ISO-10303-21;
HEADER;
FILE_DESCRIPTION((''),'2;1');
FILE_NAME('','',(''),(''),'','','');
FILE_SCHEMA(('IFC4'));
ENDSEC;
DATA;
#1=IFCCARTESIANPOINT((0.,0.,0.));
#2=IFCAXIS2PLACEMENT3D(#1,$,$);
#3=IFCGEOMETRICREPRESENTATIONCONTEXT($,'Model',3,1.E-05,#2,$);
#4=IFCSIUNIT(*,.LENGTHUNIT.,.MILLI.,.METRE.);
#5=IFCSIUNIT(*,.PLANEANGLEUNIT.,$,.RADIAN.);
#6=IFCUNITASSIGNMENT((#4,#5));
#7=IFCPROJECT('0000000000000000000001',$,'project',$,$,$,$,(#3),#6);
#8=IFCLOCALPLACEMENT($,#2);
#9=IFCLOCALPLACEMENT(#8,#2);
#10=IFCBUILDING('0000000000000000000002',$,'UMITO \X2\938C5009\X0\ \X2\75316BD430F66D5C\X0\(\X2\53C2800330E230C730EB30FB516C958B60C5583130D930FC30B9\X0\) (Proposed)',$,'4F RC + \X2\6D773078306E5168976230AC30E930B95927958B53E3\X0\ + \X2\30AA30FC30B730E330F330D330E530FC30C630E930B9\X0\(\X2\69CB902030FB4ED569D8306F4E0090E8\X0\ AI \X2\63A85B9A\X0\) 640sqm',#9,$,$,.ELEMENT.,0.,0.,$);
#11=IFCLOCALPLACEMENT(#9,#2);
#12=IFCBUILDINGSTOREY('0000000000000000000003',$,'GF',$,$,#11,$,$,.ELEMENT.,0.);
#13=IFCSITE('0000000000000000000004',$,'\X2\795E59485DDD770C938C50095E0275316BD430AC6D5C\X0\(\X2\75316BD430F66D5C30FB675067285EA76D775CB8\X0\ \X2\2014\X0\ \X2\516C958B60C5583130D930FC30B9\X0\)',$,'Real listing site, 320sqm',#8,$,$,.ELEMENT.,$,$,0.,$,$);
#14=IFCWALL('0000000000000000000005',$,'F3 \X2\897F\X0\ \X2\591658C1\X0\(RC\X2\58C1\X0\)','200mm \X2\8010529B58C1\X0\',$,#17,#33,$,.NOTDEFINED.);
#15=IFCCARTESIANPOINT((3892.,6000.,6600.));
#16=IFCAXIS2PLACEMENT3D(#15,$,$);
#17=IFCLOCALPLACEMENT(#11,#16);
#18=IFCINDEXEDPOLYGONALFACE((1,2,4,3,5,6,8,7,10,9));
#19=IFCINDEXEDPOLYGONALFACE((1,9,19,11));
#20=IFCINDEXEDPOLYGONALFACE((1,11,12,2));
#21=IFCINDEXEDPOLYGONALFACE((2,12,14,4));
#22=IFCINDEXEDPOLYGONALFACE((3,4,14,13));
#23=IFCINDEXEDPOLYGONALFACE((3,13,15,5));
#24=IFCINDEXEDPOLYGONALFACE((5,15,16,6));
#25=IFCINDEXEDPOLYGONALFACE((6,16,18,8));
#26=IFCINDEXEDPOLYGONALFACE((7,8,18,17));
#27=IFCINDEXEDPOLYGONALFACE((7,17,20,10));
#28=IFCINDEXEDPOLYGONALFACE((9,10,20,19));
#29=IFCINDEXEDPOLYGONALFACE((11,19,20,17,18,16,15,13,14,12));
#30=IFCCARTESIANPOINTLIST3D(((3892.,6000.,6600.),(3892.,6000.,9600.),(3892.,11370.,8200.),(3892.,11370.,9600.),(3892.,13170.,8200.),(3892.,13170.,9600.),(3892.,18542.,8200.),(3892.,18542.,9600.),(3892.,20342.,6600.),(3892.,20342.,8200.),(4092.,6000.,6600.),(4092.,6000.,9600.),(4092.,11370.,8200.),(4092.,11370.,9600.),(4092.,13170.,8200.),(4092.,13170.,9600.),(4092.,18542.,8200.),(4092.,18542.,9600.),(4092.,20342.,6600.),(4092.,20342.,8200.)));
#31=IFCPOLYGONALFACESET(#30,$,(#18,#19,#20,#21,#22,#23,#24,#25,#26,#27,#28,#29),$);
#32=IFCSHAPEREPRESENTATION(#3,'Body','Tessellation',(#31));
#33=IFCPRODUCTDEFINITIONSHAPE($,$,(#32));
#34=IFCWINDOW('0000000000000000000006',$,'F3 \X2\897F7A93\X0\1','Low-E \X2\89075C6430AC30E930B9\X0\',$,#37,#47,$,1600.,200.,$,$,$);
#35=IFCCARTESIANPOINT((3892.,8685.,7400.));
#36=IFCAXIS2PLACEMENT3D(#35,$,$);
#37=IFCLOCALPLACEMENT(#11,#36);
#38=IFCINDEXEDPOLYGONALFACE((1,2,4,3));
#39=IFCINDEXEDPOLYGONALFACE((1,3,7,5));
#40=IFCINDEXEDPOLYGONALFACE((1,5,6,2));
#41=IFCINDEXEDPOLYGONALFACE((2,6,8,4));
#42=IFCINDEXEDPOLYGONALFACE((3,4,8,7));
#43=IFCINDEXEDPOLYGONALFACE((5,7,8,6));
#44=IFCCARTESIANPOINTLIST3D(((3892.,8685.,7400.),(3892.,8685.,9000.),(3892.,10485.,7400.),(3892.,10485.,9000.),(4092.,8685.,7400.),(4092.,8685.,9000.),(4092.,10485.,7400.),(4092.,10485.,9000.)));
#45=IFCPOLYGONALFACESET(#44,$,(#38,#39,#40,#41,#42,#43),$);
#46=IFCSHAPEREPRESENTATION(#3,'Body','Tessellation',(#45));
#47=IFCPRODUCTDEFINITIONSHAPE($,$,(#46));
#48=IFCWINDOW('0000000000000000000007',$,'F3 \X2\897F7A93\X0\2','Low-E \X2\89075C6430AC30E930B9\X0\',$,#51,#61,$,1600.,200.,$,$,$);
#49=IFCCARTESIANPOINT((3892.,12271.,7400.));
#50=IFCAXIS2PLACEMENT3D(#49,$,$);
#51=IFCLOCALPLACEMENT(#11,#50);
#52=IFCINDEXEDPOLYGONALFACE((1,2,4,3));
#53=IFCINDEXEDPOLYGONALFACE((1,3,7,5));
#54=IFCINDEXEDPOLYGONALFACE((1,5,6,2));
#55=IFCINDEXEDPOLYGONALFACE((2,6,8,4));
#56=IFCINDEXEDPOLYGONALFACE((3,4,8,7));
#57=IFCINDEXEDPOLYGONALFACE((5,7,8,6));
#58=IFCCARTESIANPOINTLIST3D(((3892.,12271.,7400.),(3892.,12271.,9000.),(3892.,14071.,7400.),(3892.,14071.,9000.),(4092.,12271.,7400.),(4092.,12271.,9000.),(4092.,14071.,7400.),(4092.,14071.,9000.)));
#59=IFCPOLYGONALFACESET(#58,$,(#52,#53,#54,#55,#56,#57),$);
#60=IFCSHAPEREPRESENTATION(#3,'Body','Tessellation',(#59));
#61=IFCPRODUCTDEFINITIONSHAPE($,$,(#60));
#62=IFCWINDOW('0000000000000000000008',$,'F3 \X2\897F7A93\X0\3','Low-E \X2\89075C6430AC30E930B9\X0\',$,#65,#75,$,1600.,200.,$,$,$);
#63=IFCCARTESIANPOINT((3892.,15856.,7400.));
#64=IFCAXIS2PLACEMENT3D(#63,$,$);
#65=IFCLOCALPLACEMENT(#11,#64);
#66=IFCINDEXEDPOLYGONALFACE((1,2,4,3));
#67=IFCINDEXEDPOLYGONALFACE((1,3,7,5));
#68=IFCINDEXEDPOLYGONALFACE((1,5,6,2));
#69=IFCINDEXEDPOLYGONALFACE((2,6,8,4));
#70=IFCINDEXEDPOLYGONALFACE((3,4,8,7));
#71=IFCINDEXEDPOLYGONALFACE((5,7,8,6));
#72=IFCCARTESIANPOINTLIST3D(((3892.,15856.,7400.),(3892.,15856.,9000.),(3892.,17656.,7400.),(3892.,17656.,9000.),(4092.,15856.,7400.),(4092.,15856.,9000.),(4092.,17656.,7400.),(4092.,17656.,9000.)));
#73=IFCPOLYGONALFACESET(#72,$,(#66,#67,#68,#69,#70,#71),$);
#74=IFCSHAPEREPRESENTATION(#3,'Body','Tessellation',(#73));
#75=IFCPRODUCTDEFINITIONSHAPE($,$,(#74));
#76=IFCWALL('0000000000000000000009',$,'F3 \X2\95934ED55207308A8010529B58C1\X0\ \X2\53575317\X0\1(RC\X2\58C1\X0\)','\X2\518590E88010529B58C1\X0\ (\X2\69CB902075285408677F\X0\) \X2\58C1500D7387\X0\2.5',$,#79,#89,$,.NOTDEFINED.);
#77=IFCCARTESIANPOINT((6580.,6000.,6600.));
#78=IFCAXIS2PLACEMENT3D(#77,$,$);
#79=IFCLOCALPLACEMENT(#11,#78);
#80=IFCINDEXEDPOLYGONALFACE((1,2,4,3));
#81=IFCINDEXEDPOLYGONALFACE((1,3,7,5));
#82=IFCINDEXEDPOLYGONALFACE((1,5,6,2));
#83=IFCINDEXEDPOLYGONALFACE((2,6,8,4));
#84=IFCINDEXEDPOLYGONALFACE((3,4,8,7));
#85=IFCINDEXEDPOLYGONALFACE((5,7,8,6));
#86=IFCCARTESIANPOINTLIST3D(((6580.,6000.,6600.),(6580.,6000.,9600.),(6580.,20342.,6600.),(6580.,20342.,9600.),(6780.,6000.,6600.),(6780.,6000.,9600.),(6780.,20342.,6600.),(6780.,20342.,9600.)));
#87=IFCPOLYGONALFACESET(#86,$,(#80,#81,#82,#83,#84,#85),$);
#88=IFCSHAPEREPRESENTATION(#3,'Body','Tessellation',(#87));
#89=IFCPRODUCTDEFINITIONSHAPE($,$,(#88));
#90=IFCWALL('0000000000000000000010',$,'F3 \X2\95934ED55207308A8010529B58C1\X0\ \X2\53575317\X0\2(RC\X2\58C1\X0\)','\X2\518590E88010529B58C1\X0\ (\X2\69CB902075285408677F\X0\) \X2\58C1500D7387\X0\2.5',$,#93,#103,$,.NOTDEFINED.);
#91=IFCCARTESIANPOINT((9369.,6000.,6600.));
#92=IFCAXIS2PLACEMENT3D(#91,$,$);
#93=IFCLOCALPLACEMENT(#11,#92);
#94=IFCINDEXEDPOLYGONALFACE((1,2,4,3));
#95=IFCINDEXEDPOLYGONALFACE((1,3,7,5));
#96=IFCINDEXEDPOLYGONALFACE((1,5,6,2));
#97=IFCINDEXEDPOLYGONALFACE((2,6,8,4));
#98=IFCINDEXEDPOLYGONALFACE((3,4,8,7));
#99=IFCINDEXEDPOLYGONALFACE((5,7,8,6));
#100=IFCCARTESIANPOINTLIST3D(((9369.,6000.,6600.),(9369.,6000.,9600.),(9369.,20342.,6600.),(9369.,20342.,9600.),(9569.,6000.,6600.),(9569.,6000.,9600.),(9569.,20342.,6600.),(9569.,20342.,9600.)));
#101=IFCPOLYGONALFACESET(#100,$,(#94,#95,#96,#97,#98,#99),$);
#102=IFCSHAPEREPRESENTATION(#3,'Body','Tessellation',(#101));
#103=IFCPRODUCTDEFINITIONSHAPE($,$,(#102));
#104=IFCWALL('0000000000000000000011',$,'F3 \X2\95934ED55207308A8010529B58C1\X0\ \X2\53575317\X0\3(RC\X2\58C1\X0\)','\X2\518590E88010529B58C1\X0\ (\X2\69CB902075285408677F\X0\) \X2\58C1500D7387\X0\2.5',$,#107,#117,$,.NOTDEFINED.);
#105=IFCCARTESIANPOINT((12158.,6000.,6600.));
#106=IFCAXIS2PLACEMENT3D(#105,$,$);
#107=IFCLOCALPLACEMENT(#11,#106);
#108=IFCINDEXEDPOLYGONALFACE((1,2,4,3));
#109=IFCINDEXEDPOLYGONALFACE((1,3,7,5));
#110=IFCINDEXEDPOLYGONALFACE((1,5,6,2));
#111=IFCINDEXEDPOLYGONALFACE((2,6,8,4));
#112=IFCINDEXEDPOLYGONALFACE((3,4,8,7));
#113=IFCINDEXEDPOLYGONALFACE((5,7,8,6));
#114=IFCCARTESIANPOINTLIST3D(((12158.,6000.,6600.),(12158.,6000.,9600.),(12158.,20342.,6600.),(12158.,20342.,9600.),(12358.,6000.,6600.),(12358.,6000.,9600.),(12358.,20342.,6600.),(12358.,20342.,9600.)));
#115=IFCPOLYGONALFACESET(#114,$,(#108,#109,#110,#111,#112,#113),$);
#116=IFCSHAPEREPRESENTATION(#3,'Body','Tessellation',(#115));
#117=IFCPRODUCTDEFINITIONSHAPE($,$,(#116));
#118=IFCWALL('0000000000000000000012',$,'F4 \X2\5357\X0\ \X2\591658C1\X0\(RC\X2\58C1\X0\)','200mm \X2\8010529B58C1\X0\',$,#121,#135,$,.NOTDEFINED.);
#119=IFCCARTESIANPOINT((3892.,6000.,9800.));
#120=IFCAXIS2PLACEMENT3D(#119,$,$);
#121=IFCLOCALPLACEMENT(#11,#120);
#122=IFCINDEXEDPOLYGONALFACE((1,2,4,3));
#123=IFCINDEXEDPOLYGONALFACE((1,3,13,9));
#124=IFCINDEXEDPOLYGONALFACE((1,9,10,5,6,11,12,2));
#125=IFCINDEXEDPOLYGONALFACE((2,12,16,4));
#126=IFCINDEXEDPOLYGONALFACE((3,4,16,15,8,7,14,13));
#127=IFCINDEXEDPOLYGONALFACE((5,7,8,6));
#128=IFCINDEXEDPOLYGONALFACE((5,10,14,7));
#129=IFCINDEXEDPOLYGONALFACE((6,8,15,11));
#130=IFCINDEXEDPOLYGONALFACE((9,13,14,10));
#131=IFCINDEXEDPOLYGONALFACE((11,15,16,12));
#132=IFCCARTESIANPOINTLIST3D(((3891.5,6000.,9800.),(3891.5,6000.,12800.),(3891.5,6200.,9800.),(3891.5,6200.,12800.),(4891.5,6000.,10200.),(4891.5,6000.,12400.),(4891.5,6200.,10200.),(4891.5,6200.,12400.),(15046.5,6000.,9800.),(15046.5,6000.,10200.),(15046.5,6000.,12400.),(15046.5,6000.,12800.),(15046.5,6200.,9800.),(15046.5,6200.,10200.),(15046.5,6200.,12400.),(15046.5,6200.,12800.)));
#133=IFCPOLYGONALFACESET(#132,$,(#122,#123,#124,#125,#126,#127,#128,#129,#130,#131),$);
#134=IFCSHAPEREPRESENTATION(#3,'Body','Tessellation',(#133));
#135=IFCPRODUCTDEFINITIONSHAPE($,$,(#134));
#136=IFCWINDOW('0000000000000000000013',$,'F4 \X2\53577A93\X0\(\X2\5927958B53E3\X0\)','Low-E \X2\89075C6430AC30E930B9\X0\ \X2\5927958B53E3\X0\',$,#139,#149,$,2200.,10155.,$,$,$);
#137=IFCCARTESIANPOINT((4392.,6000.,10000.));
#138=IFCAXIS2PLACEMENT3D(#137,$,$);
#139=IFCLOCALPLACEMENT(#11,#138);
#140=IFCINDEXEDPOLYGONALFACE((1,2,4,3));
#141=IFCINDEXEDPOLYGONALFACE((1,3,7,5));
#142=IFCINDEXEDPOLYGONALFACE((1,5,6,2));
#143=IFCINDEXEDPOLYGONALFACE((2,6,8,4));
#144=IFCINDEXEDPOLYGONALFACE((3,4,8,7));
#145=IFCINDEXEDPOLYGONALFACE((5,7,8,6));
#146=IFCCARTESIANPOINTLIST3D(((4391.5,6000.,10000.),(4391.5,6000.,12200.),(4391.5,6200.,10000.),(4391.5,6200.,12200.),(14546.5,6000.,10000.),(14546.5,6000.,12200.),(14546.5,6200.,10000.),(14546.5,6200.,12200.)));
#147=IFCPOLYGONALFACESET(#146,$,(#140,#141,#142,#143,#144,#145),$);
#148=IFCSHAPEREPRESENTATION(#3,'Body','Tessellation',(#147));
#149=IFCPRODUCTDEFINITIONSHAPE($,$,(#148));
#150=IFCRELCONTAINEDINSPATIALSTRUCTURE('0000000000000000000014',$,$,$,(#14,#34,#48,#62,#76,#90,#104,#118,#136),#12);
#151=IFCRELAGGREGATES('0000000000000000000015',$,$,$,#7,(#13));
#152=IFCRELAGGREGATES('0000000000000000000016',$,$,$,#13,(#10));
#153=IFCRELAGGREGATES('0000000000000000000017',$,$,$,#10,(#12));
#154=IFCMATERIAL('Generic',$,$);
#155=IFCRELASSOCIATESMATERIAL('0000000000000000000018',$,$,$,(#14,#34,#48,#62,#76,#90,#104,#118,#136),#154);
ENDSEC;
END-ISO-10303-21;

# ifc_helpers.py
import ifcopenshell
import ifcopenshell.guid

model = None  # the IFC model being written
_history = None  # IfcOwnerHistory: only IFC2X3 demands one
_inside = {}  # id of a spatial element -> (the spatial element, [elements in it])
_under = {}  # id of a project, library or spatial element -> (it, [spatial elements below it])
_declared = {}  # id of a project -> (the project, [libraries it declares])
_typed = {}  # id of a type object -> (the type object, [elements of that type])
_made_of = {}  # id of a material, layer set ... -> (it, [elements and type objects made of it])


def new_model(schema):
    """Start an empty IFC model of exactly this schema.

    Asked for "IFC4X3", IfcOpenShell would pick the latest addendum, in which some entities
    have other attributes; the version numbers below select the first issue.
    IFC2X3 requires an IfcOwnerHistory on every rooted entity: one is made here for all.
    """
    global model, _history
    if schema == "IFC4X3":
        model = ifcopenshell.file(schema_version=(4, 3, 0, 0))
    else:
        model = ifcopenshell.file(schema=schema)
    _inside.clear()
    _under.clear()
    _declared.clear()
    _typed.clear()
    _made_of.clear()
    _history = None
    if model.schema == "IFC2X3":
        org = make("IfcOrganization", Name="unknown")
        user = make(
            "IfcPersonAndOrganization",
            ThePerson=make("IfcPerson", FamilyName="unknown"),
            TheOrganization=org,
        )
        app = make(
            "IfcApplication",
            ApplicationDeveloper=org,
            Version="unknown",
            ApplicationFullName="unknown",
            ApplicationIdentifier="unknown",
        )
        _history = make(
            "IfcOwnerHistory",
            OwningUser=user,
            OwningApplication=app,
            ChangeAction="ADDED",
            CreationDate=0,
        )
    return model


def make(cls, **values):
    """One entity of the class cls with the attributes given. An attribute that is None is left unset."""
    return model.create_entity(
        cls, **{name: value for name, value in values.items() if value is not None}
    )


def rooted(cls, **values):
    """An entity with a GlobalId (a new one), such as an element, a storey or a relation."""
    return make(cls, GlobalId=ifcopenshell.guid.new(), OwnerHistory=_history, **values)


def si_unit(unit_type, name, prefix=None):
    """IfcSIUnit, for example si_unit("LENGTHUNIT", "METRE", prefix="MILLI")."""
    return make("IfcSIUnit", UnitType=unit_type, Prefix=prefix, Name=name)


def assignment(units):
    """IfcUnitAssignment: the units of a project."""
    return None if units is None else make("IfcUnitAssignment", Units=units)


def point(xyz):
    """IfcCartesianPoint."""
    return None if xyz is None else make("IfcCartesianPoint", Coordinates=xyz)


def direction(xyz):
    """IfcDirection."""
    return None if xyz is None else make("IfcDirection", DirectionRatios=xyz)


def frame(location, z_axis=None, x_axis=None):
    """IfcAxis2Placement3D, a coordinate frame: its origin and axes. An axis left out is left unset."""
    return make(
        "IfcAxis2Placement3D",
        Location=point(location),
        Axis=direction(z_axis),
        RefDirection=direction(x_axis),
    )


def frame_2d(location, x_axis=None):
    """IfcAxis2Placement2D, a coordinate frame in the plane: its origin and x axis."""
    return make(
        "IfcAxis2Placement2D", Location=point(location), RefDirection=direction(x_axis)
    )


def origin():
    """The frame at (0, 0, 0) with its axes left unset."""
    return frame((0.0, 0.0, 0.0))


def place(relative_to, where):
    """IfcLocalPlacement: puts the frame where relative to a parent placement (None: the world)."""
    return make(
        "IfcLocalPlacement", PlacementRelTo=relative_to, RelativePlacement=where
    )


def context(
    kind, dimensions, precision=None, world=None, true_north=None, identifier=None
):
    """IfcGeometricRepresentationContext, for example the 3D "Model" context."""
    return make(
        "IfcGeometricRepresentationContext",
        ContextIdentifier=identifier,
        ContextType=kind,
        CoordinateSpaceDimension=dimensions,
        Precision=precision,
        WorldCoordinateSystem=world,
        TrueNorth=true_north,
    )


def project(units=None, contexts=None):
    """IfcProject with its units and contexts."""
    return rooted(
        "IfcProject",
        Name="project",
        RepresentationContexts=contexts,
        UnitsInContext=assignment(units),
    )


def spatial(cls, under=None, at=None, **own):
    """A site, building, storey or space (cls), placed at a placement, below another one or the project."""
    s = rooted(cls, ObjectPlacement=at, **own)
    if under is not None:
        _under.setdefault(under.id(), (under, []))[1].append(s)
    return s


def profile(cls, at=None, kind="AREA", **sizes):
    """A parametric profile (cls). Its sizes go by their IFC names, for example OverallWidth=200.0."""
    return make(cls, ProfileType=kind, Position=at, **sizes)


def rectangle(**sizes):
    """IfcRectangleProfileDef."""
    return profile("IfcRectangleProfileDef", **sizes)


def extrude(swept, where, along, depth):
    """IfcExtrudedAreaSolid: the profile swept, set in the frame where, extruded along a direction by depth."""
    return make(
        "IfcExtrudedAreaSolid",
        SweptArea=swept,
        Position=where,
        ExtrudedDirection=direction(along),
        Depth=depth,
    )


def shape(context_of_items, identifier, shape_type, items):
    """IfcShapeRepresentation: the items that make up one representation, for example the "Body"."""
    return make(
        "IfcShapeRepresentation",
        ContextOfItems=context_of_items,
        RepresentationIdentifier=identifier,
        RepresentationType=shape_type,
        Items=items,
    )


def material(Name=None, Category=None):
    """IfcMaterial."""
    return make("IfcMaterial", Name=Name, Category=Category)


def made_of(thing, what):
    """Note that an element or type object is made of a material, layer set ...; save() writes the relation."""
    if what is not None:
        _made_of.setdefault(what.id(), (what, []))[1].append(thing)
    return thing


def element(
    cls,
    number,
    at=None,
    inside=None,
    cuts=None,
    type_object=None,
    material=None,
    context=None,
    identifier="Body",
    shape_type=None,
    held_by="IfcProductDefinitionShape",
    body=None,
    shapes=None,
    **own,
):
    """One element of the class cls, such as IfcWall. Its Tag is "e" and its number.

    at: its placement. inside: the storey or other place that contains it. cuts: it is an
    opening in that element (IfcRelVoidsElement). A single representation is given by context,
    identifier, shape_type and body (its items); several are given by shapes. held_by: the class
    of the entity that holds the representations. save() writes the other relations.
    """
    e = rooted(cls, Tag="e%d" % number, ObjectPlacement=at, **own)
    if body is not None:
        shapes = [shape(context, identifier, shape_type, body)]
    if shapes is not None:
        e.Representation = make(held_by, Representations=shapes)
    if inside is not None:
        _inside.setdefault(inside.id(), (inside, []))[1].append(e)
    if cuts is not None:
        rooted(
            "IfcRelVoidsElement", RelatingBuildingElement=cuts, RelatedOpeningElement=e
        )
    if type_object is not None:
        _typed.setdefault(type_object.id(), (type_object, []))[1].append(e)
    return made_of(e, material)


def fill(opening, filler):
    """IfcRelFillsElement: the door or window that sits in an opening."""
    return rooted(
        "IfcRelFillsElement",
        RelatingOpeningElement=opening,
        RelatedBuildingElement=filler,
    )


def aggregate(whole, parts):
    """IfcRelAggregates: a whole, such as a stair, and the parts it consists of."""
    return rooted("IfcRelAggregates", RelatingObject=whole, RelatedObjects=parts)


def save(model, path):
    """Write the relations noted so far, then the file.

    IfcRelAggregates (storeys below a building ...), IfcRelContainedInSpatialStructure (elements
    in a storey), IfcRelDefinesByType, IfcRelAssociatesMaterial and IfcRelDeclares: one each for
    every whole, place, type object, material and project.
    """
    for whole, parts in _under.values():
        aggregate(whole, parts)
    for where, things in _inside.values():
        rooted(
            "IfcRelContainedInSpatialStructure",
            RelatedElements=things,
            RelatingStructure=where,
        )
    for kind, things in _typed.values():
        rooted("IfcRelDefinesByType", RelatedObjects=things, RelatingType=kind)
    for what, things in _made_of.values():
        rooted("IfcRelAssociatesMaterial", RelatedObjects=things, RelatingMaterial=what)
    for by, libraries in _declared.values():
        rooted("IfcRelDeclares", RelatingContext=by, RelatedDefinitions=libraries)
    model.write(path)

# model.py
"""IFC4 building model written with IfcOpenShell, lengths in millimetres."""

from ifc_helpers import new_model, si_unit, frame, frame_2d, origin, place, context, project, spatial, rectangle, extrude, material, element, fill, save


model = new_model("IFC4")

# Units and contexts
model_context = context("Model", 3, precision=1e-05, world=origin())
ifc_project = project(units=[si_unit("LENGTHUNIT", "METRE", prefix="MILLI"), si_unit("PLANEANGLEUNIT", "RADIAN")], contexts=[model_context])

# Site, building, storey
site_placement = place(None, origin())
site = spatial("IfcSite", under=ifc_project, at=site_placement, Name="神奈川県鎌倉市由比ガ浜(由比ヶ浜・材木座海岸 — 公開情報ベース)", ObjectType="Real listing site, 320sqm", CompositionType="ELEMENT", RefElevation=0.0)
building_placement = place(site_placement, origin())
building = spatial("IfcBuilding", under=site, at=building_placement, Name="UMITO 鎌倉 由比ヶ浜(参考モデル・公開情報ベース) (Proposed)", ObjectType="4F RC + 海への全面ガラス大開口 + オーシャンビューテラス(構造・仕様は一部 AI 推定) 640sqm", CompositionType="ELEMENT", ElevationOfRefHeight=0.0, ElevationOfTerrain=0.0)
storey_placement = place(building_placement, origin())
storey = spatial("IfcBuildingStorey", under=building, at=storey_placement, Name="GF", CompositionType="ELEMENT", Elevation=0.0)

# Shared definitions
ifc_material_1 = material(Name="Generic")

# Wall, openings, windows
wall_1_placement = place(storey_placement, frame((3892.0, 6000.0, 6600.0)))
wall_1 = element("IfcWall", 1, at=wall_1_placement, inside=storey, material=ifc_material_1, Name="F3 西 外壁(RC壁)", Description="200mm 耐力壁", PredefinedType="NOTDEFINED", context=model_context, shape_type="SweptSolid", body=[
    extrude(rectangle(XDim=200.0, YDim=14342.0, at=frame_2d((100.0, 7171.0))), frame((3892.0, 6000.0, 6600.0)), (0.0, 0.0, 1.0), 3000.0),
])
opening_1_placement = place(storey_placement, frame((3892.0, 8685.0, 7400.0)))
opening_1 = element("IfcOpeningElement", 2, at=opening_1_placement, cuts=wall_1, PredefinedType="NOTDEFINED", context=model_context, shape_type="SweptSolid", body=[
    extrude(rectangle(XDim=200.0, YDim=1800.0, at=frame_2d((100.0, 900.0))), frame((3892.0, 8685.0, 7400.0)), (0.0, 0.0, 1.0), 1600.0),
])
opening_2_placement = place(storey_placement, frame((3892.0, 12271.0, 7400.0)))
opening_2 = element("IfcOpeningElement", 3, at=opening_2_placement, cuts=wall_1, PredefinedType="NOTDEFINED", context=model_context, shape_type="SweptSolid", body=[
    extrude(rectangle(XDim=200.0, YDim=1800.0, at=frame_2d((100.0, 900.0))), frame((3892.0, 12271.0, 7400.0)), (0.0, 0.0, 1.0), 1600.0),
])
opening_3_placement = place(storey_placement, frame((3892.0, 15856.0, 7400.0)))
opening_3 = element("IfcOpeningElement", 4, at=opening_3_placement, cuts=wall_1, PredefinedType="NOTDEFINED", context=model_context, shape_type="SweptSolid", body=[
    extrude(rectangle(XDim=200.0, YDim=1800.0, at=frame_2d((100.0, 900.0))), frame((3892.0, 15856.0, 7400.0)), (0.0, 0.0, 1.0), 1600.0),
])
window_1_placement = place(storey_placement, frame((3892.0, 8685.0, 7400.0)))
window_1 = element("IfcWindow", 5, at=window_1_placement, inside=storey, material=ifc_material_1, Name="F3 西窓1", Description="Low-E 複層ガラス", OverallHeight=1600.0, OverallWidth=200.0, context=model_context, shape_type="SweptSolid", body=[
    extrude(rectangle(XDim=200.0, YDim=1800.0, at=frame_2d((100.0, 900.0))), frame((3892.0, 8685.0, 7400.0)), (0.0, 0.0, 1.0), 1600.0),
])
fill(opening_1, window_1)
window_2_placement = place(storey_placement, frame((3892.0, 12271.0, 7400.0)))
window_2 = element("IfcWindow", 6, at=window_2_placement, inside=storey, material=ifc_material_1, Name="F3 西窓2", Description="Low-E 複層ガラス", OverallHeight=1600.0, OverallWidth=200.0, context=model_context, shape_type="SweptSolid", body=[
    extrude(rectangle(XDim=200.0, YDim=1800.0, at=frame_2d((100.0, 900.0))), frame((3892.0, 12271.0, 7400.0)), (0.0, 0.0, 1.0), 1600.0),
])
fill(opening_2, window_2)
window_3_placement = place(storey_placement, frame((3892.0, 15856.0, 7400.0)))
window_3 = element("IfcWindow", 7, at=window_3_placement, inside=storey, material=ifc_material_1, Name="F3 西窓3", Description="Low-E 複層ガラス", OverallHeight=1600.0, OverallWidth=200.0, context=model_context, shape_type="SweptSolid", body=[
    extrude(rectangle(XDim=200.0, YDim=1800.0, at=frame_2d((100.0, 900.0))), frame((3892.0, 15856.0, 7400.0)), (0.0, 0.0, 1.0), 1600.0),
])
fill(opening_3, window_3)

# Walls
wall_2_placement = place(storey_placement, frame((6580.0, 6000.0, 6600.0)))
element("IfcWall", 8, at=wall_2_placement, inside=storey, material=ifc_material_1, Name="F3 間仕切り耐力壁 南北1(RC壁)", Description="内部耐力壁 (構造用合板) 壁倍率2.5", PredefinedType="NOTDEFINED", context=model_context, shape_type="SweptSolid", body=[
    extrude(rectangle(XDim=200.0, YDim=14342.0, at=frame_2d((100.0, 7171.0))), frame((6580.0, 6000.0, 6600.0)), (0.0, 0.0, 1.0), 3000.0),
])
wall_3_placement = place(storey_placement, frame((9369.0, 6000.0, 6600.0)))
element("IfcWall", 9, at=wall_3_placement, inside=storey, material=ifc_material_1, Name="F3 間仕切り耐力壁 南北2(RC壁)", Description="内部耐力壁 (構造用合板) 壁倍率2.5", PredefinedType="NOTDEFINED", context=model_context, shape_type="SweptSolid", body=[
    extrude(rectangle(XDim=200.0, YDim=14342.0, at=frame_2d((100.0, 7171.0))), frame((9369.0, 6000.0, 6600.0)), (0.0, 0.0, 1.0), 3000.0),
])
wall_4_placement = place(storey_placement, frame((12158.0, 6000.0, 6600.0)))
element("IfcWall", 10, at=wall_4_placement, inside=storey, material=ifc_material_1, Name="F3 間仕切り耐力壁 南北3(RC壁)", Description="内部耐力壁 (構造用合板) 壁倍率2.5", PredefinedType="NOTDEFINED", context=model_context, shape_type="SweptSolid", body=[
    extrude(rectangle(XDim=200.0, YDim=14342.0, at=frame_2d((100.0, 7171.0))), frame((12158.0, 6000.0, 6600.0)), (0.0, 0.0, 1.0), 3000.0),
])

# Wall, opening, window
wall_5_placement = place(storey_placement, frame((3892.0, 6000.0, 9800.0)))
wall_5 = element("IfcWall", 11, at=wall_5_placement, inside=storey, material=ifc_material_1, Name="F4 南 外壁(RC壁)", Description="200mm 耐力壁", PredefinedType="NOTDEFINED", context=model_context, shape_type="SweptSolid", body=[
    extrude(rectangle(XDim=11155.0, YDim=200.0, at=frame_2d((5577.0, 100.0))), frame((3892.0, 6000.0, 9800.0)), (0.0, 0.0, 1.0), 3000.0),
])
opening_4_placement = place(storey_placement, frame((4392.0, 6000.0, 10000.0)))
opening_4 = element("IfcOpeningElement", 12, at=opening_4_placement, cuts=wall_5, PredefinedType="NOTDEFINED", context=model_context, shape_type="SweptSolid", body=[
    extrude(rectangle(XDim=10155.0, YDim=200.0, at=frame_2d((5077.0, 100.0))), frame((4392.0, 6000.0, 10000.0)), (0.0, 0.0, 1.0), 2200.0),
])
window_4_placement = place(storey_placement, frame((4392.0, 6000.0, 10000.0)))
window_4 = element("IfcWindow", 13, at=window_4_placement, inside=storey, material=ifc_material_1, Name="F4 南窓(大開口)", Description="Low-E 複層ガラス 大開口", OverallHeight=2200.0, OverallWidth=10155.0, context=model_context, shape_type="SweptSolid", body=[
    extrude(rectangle(XDim=10155.0, YDim=200.0, at=frame_2d((5077.0, 100.0))), frame((4392.0, 6000.0, 10000.0)), (0.0, 0.0, 1.0), 2200.0),
])
fill(opening_4, window_4)

save(model, "model.ifc")
